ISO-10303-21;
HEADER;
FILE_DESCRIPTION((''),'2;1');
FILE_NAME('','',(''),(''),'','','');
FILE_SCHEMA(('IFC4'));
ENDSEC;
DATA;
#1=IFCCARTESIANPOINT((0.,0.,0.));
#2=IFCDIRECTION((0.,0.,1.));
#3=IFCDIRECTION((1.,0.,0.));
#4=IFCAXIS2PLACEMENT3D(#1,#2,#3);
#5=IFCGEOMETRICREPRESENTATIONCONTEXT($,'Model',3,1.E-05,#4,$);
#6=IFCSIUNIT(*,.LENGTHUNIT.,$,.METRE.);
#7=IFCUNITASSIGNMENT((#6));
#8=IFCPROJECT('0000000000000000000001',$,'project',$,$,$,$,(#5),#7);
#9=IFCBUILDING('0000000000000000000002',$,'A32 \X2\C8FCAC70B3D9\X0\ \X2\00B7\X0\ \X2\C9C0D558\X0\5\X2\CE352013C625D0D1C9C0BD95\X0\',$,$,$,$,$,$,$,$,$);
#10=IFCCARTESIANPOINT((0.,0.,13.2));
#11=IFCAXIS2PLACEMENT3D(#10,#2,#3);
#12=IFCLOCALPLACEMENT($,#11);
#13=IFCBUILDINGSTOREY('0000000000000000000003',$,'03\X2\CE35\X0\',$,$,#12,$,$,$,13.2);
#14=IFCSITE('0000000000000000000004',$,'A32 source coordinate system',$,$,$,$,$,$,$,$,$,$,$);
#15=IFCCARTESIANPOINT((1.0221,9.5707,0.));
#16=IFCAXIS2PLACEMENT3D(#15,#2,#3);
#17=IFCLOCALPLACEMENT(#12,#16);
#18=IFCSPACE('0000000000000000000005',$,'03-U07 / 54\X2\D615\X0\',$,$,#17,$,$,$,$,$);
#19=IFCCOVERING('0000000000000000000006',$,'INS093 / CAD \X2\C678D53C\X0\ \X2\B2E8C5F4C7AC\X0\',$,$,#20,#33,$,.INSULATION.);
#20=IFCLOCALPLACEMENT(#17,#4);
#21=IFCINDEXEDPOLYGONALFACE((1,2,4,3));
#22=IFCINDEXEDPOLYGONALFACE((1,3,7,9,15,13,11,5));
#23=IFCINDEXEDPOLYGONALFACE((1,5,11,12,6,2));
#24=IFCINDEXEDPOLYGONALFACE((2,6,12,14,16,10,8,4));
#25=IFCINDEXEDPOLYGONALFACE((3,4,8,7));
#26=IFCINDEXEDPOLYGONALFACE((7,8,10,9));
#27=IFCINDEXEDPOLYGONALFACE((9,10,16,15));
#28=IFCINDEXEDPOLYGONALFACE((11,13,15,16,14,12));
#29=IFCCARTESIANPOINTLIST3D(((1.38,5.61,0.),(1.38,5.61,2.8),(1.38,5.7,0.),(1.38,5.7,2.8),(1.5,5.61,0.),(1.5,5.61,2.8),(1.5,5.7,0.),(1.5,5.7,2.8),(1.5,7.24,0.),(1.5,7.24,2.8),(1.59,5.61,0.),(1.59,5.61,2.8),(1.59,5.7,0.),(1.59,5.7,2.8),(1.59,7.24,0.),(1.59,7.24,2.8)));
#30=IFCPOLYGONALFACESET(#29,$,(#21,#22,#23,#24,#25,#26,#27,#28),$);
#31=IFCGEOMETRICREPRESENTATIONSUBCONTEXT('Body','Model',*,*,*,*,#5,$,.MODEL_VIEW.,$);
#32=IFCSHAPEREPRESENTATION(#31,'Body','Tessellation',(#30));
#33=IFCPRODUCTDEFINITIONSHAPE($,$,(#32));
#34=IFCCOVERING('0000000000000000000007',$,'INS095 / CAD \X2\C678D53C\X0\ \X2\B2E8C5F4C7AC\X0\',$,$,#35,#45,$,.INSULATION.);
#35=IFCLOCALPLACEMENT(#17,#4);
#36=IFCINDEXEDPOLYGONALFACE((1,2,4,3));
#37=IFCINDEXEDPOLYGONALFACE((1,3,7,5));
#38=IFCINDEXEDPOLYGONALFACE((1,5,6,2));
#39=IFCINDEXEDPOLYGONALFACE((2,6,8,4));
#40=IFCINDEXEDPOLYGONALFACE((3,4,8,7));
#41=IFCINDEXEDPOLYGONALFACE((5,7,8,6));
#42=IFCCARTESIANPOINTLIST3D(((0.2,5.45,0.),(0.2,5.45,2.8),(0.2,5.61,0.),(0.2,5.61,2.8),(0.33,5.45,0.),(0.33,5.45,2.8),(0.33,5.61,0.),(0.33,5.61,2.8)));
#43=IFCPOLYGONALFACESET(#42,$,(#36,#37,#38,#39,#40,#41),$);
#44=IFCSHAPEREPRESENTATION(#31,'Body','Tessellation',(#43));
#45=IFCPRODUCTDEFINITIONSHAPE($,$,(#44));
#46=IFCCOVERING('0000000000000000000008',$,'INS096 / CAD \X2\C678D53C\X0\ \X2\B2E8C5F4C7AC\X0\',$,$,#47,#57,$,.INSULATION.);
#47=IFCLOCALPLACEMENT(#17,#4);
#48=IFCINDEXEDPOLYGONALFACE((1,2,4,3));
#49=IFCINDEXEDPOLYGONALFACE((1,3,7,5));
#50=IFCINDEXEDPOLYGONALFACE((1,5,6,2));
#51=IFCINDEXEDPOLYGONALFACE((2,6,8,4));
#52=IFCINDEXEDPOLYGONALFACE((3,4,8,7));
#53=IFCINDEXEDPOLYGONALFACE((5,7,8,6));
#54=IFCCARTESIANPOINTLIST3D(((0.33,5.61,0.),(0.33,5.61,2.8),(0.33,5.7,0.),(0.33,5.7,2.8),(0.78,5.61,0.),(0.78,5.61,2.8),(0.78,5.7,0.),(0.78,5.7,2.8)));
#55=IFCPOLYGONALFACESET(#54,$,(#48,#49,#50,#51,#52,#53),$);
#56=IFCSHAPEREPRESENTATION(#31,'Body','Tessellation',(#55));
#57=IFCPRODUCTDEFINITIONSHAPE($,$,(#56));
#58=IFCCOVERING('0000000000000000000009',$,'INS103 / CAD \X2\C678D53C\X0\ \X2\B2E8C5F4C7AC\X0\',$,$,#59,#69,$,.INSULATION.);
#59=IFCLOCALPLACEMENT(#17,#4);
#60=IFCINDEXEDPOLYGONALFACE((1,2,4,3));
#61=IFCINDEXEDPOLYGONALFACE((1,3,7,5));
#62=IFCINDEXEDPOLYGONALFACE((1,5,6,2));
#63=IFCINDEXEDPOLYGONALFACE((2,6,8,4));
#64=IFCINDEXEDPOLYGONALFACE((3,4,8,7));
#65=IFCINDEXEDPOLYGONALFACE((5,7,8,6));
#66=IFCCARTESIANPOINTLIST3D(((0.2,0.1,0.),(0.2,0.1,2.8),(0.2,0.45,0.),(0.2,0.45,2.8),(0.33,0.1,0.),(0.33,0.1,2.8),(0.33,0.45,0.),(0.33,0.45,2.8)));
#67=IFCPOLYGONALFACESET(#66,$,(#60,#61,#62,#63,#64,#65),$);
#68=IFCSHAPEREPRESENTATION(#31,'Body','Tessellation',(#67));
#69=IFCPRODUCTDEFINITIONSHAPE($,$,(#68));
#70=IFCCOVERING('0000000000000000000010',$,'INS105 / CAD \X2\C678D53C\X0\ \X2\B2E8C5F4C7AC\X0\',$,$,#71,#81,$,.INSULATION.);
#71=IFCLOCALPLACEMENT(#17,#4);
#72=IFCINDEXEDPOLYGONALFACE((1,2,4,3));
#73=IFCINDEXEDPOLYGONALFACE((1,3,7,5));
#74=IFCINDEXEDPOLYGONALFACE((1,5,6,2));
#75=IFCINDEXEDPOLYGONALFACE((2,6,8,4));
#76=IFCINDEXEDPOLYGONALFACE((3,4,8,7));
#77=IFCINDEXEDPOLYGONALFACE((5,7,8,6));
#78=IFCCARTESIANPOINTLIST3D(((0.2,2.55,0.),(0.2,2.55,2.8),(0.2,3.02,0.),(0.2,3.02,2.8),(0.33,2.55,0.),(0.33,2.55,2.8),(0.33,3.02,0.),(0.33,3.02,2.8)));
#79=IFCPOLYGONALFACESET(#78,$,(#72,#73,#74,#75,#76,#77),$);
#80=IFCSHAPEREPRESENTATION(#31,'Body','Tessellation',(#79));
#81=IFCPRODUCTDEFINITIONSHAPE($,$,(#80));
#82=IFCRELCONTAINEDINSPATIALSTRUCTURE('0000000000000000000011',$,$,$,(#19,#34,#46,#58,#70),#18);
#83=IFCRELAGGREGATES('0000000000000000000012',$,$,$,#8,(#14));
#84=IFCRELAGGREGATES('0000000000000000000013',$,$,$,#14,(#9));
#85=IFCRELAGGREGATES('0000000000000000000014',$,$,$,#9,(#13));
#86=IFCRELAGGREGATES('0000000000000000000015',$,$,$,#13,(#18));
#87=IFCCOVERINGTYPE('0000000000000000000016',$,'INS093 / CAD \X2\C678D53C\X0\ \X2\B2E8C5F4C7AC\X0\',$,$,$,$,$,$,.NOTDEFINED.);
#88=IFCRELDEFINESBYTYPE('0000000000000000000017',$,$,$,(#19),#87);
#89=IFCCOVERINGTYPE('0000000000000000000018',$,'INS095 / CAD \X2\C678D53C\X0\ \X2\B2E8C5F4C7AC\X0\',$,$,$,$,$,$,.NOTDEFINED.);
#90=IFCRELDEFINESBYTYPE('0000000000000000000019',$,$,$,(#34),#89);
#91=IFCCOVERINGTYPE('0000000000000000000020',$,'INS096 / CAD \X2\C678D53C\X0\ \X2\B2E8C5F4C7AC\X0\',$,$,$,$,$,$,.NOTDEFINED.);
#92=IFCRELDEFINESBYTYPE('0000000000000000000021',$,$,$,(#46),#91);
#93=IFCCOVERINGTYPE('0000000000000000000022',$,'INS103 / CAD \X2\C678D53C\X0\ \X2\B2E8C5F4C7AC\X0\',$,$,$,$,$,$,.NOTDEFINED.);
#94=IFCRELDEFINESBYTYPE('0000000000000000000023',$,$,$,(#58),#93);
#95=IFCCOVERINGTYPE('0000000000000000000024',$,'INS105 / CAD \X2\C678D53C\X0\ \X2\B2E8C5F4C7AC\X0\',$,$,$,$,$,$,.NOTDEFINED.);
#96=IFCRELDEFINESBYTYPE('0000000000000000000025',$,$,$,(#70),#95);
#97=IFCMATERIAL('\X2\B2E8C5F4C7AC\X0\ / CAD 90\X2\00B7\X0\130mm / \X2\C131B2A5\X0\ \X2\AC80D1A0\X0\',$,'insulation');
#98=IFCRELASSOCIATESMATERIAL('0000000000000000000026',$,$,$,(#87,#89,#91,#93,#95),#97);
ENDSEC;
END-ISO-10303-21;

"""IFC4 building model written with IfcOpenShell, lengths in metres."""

from ifc_helpers import new_model, si_unit, frame, origin, origin_with_axes, place, context, subcontext, project, spatial, polyline, outline, extrude, source, transform, mapped, material, type_object, type_shapes, element, save


model = new_model("IFC4")

# Units and contexts
model_context = context("Model", 3, precision=1e-05, world=origin_with_axes())
body_context = subcontext(model_context, "Body", "Model", "MODEL_VIEW")
ifc_project = project(units=[si_unit("LENGTHUNIT", "METRE")], contexts=[model_context])

# Site, building, storey, space
storey_placement = place(None, frame((0.0, 0.0, 13.2), z_axis=(0.0, 0.0, 1.0), x_axis=(1.0, 0.0, 0.0)))
space_placement = place(storey_placement, frame((1.0221, 9.5707, 0.0), z_axis=(0.0, 0.0, 1.0), x_axis=(1.0, 0.0, 0.0)))
site = spatial("IfcSite", under=ifc_project, Name="A32 source coordinate system")
building = spatial("IfcBuilding", under=site, Name="A32 주거동 · 지하5층–옥탑지붕")
storey = spatial("IfcBuildingStorey", under=building, at=storey_placement, Name="03층", Elevation=13.2)
space = spatial("IfcSpace", under=storey, at=space_placement, Name="03-U07 / 54형")

# Coverings
ifc_material = material(Name="단열재 / CAD 90·130mm / 성능 검토", Category="insulation")
covering_type_1 = type_object("IfcCoveringType", Name="INS093 / CAD 외피 단열재", PredefinedType="NOTDEFINED", material=ifc_material)
shared_shape_1 = source(origin(), body_context, "Body", "SweptSolid", [
    extrude(outline(polyline([(1.5, 5.7), (1.5, 7.24), (1.59, 7.24), (1.59, 5.7), (1.59, 5.61), (1.5, 5.61), (1.38, 5.61), (1.38, 5.7), (1.5, 5.7)])), origin(), (0.0, 0.0, 1.0), 2.8),
])
type_shapes(covering_type_1, [shared_shape_1])
covering_1_placement = place(space_placement, origin_with_axes())
element("IfcCovering", 1, at=covering_1_placement, inside=space, type_object=covering_type_1, Name="INS093 / CAD 외피 단열재", PredefinedType="INSULATION", context=body_context, shape_type="MappedRepresentation", body=[
    mapped(shared_shape_1, transform((0.0, 0.0, 0.0), scale=1.0)),
])
covering_type_2 = type_object("IfcCoveringType", Name="INS095 / CAD 외피 단열재", PredefinedType="NOTDEFINED", material=ifc_material)
shared_shape_2 = source(origin(), body_context, "Body", "SweptSolid", [
    extrude(outline(polyline([(0.2, 5.61), (0.33, 5.61), (0.33, 5.45), (0.2, 5.45), (0.2, 5.61)])), origin(), (0.0, 0.0, 1.0), 2.8),
])
type_shapes(covering_type_2, [shared_shape_2])
covering_2_placement = place(space_placement, origin_with_axes())
element("IfcCovering", 2, at=covering_2_placement, inside=space, type_object=covering_type_2, Name="INS095 / CAD 외피 단열재", PredefinedType="INSULATION", context=body_context, shape_type="MappedRepresentation", body=[
    mapped(shared_shape_2, transform((0.0, 0.0, 0.0), scale=1.0)),
])
covering_type_3 = type_object("IfcCoveringType", Name="INS096 / CAD 외피 단열재", PredefinedType="NOTDEFINED", material=ifc_material)
shared_shape_3 = source(origin(), body_context, "Body", "SweptSolid", [
    extrude(outline(polyline([(0.78, 5.7), (0.78, 5.61), (0.33, 5.61), (0.33, 5.7), (0.78, 5.7)])), origin(), (0.0, 0.0, 1.0), 2.8),
])
type_shapes(covering_type_3, [shared_shape_3])
covering_3_placement = place(space_placement, origin_with_axes())
element("IfcCovering", 3, at=covering_3_placement, inside=space, type_object=covering_type_3, Name="INS096 / CAD 외피 단열재", PredefinedType="INSULATION", context=body_context, shape_type="MappedRepresentation", body=[
    mapped(shared_shape_3, transform((0.0, 0.0, 0.0), scale=1.0)),
])
covering_type_4 = type_object("IfcCoveringType", Name="INS103 / CAD 외피 단열재", PredefinedType="NOTDEFINED", material=ifc_material)
shared_shape_4 = source(origin(), body_context, "Body", "SweptSolid", [
    extrude(outline(polyline([(0.2, 0.45), (0.33, 0.45), (0.33, 0.1), (0.2, 0.1), (0.2, 0.45)])), origin(), (0.0, 0.0, 1.0), 2.8),
])
type_shapes(covering_type_4, [shared_shape_4])
covering_4_placement = place(space_placement, origin_with_axes())
element("IfcCovering", 4, at=covering_4_placement, inside=space, type_object=covering_type_4, Name="INS103 / CAD 외피 단열재", PredefinedType="INSULATION", context=body_context, shape_type="MappedRepresentation", body=[
    mapped(shared_shape_4, transform((0.0, 0.0, 0.0), scale=1.0)),
])
covering_type_5 = type_object("IfcCoveringType", Name="INS105 / CAD 외피 단열재", PredefinedType="NOTDEFINED", material=ifc_material)
shared_shape_5 = source(origin(), body_context, "Body", "SweptSolid", [
    extrude(outline(polyline([(0.2, 3.02), (0.33, 3.02), (0.33, 2.55), (0.2, 2.55), (0.2, 3.02)])), origin(), (0.0, 0.0, 1.0), 2.8),
])
type_shapes(covering_type_5, [shared_shape_5])
covering_5_placement = place(space_placement, origin_with_axes())
element("IfcCovering", 5, at=covering_5_placement, inside=space, type_object=covering_type_5, Name="INS105 / CAD 외피 단열재", PredefinedType="INSULATION", context=body_context, shape_type="MappedRepresentation", body=[
    mapped(shared_shape_5, transform((0.0, 0.0, 0.0), scale=1.0)),
])

save(model, "model.ifc")
